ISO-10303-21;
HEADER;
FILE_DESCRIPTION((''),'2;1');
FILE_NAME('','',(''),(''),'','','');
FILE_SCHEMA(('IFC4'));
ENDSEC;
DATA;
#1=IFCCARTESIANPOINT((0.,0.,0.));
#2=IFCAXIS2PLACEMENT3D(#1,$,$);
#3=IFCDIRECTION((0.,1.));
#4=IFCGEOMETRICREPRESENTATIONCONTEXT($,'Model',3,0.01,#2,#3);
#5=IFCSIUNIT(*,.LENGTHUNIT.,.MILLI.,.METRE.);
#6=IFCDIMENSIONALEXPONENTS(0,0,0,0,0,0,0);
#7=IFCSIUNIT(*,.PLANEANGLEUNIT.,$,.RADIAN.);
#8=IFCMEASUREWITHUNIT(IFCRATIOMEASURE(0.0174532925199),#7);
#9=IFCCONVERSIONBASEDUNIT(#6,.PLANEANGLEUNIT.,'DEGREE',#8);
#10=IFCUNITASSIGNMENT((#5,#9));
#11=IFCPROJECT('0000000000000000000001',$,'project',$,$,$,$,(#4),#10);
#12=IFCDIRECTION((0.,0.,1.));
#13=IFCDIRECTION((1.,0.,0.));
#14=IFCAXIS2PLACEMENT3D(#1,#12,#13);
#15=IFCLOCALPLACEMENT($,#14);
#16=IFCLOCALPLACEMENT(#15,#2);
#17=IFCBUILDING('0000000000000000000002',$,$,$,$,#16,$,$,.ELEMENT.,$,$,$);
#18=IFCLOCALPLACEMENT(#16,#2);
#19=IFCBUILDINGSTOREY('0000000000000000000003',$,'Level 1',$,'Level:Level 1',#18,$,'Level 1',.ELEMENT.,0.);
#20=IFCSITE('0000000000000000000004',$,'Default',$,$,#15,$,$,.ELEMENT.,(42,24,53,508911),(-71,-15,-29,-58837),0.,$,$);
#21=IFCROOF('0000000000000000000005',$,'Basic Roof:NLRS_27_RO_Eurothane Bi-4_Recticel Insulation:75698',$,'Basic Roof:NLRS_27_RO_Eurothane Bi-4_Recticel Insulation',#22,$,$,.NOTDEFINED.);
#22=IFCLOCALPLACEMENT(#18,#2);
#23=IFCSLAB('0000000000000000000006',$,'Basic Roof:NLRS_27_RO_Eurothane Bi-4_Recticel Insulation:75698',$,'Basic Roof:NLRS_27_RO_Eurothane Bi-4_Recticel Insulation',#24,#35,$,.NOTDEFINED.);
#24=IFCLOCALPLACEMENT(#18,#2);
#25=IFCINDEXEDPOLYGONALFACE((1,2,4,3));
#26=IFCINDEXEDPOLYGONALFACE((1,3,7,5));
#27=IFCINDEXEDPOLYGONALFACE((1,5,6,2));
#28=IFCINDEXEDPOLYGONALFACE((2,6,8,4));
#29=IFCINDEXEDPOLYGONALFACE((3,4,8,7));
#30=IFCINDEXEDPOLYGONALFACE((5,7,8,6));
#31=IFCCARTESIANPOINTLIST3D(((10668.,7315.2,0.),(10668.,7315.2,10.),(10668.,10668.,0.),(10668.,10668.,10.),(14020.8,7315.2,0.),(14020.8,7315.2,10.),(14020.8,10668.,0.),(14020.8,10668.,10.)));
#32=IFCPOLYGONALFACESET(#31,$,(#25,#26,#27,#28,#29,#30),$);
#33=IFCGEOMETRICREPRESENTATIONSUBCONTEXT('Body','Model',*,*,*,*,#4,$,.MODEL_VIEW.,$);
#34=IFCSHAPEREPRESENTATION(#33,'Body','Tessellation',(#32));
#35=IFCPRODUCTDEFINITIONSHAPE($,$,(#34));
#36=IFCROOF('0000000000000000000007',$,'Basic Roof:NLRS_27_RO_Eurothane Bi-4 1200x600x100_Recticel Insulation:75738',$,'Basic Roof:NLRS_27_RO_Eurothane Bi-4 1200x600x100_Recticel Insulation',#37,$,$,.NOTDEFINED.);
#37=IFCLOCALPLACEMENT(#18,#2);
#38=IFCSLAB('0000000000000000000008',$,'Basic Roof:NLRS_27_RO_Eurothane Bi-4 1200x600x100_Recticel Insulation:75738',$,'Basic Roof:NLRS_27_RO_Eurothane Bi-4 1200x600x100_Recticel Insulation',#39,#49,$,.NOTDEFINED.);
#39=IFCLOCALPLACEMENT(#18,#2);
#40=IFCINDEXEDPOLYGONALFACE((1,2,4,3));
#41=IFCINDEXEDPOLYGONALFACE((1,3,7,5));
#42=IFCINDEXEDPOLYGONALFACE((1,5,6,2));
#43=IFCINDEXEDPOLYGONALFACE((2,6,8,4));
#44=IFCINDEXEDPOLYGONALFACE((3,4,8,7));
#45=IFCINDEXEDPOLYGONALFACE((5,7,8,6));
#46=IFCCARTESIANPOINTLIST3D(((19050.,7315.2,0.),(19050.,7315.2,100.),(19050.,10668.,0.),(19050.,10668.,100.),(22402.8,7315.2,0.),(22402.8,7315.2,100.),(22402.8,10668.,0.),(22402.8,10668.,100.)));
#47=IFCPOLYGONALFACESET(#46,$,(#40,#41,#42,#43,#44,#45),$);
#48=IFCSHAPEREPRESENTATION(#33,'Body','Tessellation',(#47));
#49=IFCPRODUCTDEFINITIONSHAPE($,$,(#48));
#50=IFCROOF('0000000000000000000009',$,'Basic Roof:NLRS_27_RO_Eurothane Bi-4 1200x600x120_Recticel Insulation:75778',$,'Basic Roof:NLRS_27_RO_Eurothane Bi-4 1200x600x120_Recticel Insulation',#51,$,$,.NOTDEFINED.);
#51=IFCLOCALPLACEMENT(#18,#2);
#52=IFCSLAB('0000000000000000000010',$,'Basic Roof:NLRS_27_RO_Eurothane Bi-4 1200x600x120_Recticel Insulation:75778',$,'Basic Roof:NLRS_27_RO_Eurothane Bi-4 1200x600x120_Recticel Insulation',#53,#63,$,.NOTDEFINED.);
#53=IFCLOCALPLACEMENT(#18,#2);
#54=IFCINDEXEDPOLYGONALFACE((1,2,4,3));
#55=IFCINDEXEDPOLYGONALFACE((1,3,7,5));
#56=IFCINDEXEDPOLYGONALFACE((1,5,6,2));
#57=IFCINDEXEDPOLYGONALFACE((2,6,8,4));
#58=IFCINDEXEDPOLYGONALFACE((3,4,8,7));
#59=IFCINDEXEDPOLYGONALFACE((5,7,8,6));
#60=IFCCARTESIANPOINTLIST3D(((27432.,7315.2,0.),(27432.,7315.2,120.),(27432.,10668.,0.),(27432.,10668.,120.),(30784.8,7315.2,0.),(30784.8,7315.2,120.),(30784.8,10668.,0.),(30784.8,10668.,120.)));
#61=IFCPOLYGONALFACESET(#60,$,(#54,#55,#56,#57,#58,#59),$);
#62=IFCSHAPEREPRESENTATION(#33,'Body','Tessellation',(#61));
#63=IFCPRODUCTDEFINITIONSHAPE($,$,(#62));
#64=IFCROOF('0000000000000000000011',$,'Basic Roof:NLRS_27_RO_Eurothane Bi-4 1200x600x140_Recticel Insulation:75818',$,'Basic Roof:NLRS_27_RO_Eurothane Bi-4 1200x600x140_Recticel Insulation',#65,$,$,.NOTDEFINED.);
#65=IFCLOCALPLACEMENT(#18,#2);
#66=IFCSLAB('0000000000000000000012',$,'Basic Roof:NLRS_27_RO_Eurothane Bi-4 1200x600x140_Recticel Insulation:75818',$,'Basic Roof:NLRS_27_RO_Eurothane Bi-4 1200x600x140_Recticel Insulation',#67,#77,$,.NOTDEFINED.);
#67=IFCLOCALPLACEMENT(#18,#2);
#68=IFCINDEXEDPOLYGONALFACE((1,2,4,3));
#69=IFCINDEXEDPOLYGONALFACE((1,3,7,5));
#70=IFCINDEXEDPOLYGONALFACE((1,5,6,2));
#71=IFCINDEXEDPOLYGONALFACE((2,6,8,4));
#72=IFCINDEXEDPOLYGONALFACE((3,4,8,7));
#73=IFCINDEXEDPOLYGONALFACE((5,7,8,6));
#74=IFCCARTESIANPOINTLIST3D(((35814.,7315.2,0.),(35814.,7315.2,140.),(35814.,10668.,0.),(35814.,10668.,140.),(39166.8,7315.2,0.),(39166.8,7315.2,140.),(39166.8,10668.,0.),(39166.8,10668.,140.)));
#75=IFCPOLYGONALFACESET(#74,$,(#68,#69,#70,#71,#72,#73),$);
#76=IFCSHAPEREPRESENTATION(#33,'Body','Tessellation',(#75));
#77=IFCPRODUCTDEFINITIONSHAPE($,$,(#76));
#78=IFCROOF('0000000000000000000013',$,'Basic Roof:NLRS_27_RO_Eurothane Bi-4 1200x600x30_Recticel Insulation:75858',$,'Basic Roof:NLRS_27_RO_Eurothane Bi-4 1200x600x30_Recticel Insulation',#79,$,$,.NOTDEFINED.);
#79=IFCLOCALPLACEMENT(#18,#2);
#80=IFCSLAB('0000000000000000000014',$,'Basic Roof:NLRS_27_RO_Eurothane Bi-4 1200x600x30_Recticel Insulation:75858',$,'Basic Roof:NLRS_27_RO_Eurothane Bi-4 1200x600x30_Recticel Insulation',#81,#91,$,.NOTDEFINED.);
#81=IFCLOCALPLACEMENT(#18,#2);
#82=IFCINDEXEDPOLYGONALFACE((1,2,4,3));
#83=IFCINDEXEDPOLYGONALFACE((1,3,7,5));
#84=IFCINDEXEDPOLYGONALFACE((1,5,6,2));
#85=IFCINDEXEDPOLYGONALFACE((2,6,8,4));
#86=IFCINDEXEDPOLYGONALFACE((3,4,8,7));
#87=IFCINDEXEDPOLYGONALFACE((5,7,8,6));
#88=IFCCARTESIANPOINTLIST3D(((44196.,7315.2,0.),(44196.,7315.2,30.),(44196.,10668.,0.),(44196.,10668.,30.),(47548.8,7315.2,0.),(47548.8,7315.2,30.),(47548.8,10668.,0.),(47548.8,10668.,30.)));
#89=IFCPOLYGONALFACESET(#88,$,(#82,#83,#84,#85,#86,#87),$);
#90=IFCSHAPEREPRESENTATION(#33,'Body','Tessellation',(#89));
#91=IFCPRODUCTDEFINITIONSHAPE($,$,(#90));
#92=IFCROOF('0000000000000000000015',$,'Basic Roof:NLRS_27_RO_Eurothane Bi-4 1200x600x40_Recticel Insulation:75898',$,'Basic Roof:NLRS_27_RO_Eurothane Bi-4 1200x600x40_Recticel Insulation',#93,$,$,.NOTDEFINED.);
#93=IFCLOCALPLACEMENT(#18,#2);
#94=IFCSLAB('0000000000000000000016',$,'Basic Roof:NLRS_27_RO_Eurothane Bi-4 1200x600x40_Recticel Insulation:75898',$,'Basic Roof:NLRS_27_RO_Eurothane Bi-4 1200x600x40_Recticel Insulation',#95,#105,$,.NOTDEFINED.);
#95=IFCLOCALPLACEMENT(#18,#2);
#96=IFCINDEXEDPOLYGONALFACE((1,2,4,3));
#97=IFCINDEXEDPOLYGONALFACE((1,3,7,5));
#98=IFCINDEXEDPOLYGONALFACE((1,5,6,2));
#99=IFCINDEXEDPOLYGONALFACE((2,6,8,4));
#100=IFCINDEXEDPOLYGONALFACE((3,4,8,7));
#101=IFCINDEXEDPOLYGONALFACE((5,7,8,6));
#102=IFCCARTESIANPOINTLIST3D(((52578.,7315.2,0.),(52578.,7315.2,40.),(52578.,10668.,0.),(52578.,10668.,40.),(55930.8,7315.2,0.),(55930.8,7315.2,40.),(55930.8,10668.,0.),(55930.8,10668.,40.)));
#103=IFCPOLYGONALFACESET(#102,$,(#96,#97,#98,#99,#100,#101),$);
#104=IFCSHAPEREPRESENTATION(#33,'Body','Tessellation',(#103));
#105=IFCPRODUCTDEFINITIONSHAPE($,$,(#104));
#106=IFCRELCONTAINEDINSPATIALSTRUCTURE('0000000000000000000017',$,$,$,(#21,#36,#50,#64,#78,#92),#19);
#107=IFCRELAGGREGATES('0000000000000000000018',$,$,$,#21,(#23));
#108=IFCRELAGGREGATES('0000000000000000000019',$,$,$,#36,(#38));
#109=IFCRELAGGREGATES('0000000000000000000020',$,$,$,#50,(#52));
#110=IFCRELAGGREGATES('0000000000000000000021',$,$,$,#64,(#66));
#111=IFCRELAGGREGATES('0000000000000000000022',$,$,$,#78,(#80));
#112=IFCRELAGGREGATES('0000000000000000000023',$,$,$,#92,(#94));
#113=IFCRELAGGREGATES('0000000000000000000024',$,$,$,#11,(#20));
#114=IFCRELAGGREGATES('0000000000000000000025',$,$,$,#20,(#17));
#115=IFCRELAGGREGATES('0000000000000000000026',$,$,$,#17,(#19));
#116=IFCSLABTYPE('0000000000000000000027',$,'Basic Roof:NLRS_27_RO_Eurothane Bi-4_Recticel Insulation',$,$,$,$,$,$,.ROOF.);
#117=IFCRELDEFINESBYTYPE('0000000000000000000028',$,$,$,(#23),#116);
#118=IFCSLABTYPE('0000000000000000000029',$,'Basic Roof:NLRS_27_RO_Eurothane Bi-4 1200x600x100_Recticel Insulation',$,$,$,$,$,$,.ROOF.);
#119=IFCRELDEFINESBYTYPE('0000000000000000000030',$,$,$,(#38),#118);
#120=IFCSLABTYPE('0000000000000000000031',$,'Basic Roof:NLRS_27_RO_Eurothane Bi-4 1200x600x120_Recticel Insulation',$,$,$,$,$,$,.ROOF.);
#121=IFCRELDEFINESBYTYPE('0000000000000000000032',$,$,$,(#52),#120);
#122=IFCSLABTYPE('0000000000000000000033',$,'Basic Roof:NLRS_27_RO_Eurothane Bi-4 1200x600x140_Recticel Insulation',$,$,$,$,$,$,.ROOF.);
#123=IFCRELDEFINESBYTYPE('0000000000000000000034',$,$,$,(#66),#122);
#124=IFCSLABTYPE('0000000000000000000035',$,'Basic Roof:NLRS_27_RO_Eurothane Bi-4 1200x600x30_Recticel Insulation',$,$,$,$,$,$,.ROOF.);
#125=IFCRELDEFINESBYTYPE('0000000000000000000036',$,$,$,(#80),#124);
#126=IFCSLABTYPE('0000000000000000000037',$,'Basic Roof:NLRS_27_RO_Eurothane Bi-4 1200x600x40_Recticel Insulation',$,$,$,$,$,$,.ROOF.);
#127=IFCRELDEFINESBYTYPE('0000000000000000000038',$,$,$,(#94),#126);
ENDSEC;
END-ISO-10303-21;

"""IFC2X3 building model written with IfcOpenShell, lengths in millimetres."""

from ifc_helpers import new_model, entity, si_unit, converted_unit, direction, frame, origin, origin_with_axes, origin_2d_with_axis, place, context, subcontext, project, spatial, rectangle, extrude, type_object, element, aggregate, save


model = new_model("IFC2X3")

# Units and contexts
model_context = context("Model", 3, precision=0.01, world=origin(), true_north=direction((0.0, 1.0)))
body_context = subcontext(model_context, "Body", "Model", "MODEL_VIEW")
ifc_project = project(units=[si_unit("LENGTHUNIT", "METRE", prefix="MILLI"), converted_unit("PLANEANGLEUNIT", "DEGREE", entity("IfcRatioMeasure", 0.0174532925199), si_unit("PLANEANGLEUNIT", "RADIAN"), dimensions=[0, 0, 0, 0, 0, 0, 0])], contexts=[model_context])

# Site, building, storey
site_placement = place(None, origin_with_axes())
site = spatial("IfcSite", under=ifc_project, at=site_placement, Name="Default", CompositionType="ELEMENT", RefLatitude=(42, 24, 53, 508911), RefLongitude=(-71, -15, -29, -58837), RefElevation=0.0)
building_placement = place(site_placement, origin())
building = spatial("IfcBuilding", under=site, at=building_placement, CompositionType="ELEMENT")
storey_placement = place(building_placement, origin())
storey = spatial("IfcBuildingStorey", under=building, at=storey_placement, Name="Level 1", ObjectType="Level:Level 1", LongName="Level 1", CompositionType="ELEMENT", Elevation=0.0)

# Roofs, slabs
roof_1_placement = place(storey_placement, frame((10668.0, 7315.2, 0.0)))
roof_1 = element("IfcRoof", 1, at=roof_1_placement, inside=storey, Name="Basic Roof:NLRS_27_RO_Eurothane Bi-4_Recticel Insulation:75698", ObjectType="Basic Roof:NLRS_27_RO_Eurothane Bi-4_Recticel Insulation", ShapeType="NOTDEFINED")
slab_type_1 = type_object("IfcSlabType", Name="Basic Roof:NLRS_27_RO_Eurothane Bi-4_Recticel Insulation", PredefinedType="ROOF")
slab_1_placement = place(roof_1_placement, origin())
slab_1 = element("IfcSlab", 2, at=slab_1_placement, type_object=slab_type_1, Name="Basic Roof:NLRS_27_RO_Eurothane Bi-4_Recticel Insulation:75698", ObjectType="Basic Roof:NLRS_27_RO_Eurothane Bi-4_Recticel Insulation", PredefinedType="NOTDEFINED", context=body_context, shape_type="SweptSolid", body=[
    extrude(rectangle(XDim=3352.8, YDim=3352.8, at=origin_2d_with_axis()), frame((1676.4, 1676.4, 0.0), x_axis=(-1.0, 0.0, 0.0)), (0.0, 0.0, 1.0), 10.0),
])
aggregate(roof_1, [slab_1])
roof_2_placement = place(storey_placement, frame((19050.0, 7315.2, 0.0)))
roof_2 = element("IfcRoof", 3, at=roof_2_placement, inside=storey, Name="Basic Roof:NLRS_27_RO_Eurothane Bi-4 1200x600x100_Recticel Insulation:75738", ObjectType="Basic Roof:NLRS_27_RO_Eurothane Bi-4 1200x600x100_Recticel Insulation", ShapeType="NOTDEFINED")
slab_type_2 = type_object("IfcSlabType", Name="Basic Roof:NLRS_27_RO_Eurothane Bi-4 1200x600x100_Recticel Insulation", PredefinedType="ROOF")
slab_2_placement = place(roof_2_placement, origin())
slab_2 = element("IfcSlab", 4, at=slab_2_placement, type_object=slab_type_2, Name="Basic Roof:NLRS_27_RO_Eurothane Bi-4 1200x600x100_Recticel Insulation:75738", ObjectType="Basic Roof:NLRS_27_RO_Eurothane Bi-4 1200x600x100_Recticel Insulation", PredefinedType="NOTDEFINED", context=body_context, shape_type="SweptSolid", body=[
    extrude(rectangle(XDim=3352.8, YDim=3352.8, at=origin_2d_with_axis()), frame((1676.4, 1676.4, 0.0), x_axis=(-1.0, 0.0, 0.0)), (0.0, 0.0, 1.0), 100.0),
])
aggregate(roof_2, [slab_2])
roof_3_placement = place(storey_placement, frame((27432.0, 7315.2, 0.0)))
roof_3 = element("IfcRoof", 5, at=roof_3_placement, inside=storey, Name="Basic Roof:NLRS_27_RO_Eurothane Bi-4 1200x600x120_Recticel Insulation:75778", ObjectType="Basic Roof:NLRS_27_RO_Eurothane Bi-4 1200x600x120_Recticel Insulation", ShapeType="NOTDEFINED")
slab_type_3 = type_object("IfcSlabType", Name="Basic Roof:NLRS_27_RO_Eurothane Bi-4 1200x600x120_Recticel Insulation", PredefinedType="ROOF")
slab_3_placement = place(roof_3_placement, origin())
slab_3 = element("IfcSlab", 6, at=slab_3_placement, type_object=slab_type_3, Name="Basic Roof:NLRS_27_RO_Eurothane Bi-4 1200x600x120_Recticel Insulation:75778", ObjectType="Basic Roof:NLRS_27_RO_Eurothane Bi-4 1200x600x120_Recticel Insulation", PredefinedType="NOTDEFINED", context=body_context, shape_type="SweptSolid", body=[
    extrude(rectangle(XDim=3352.8, YDim=3352.8, at=origin_2d_with_axis()), frame((1676.4, 1676.4, 0.0), x_axis=(-1.0, 0.0, 0.0)), (0.0, 0.0, 1.0), 120.0),
])
aggregate(roof_3, [slab_3])
roof_4_placement = place(storey_placement, frame((35814.0, 7315.2, 0.0)))
roof_4 = element("IfcRoof", 7, at=roof_4_placement, inside=storey, Name="Basic Roof:NLRS_27_RO_Eurothane Bi-4 1200x600x140_Recticel Insulation:75818", ObjectType="Basic Roof:NLRS_27_RO_Eurothane Bi-4 1200x600x140_Recticel Insulation", ShapeType="NOTDEFINED")
slab_type_4 = type_object("IfcSlabType", Name="Basic Roof:NLRS_27_RO_Eurothane Bi-4 1200x600x140_Recticel Insulation", PredefinedType="ROOF")
slab_4_placement = place(roof_4_placement, origin())
slab_4 = element("IfcSlab", 8, at=slab_4_placement, type_object=slab_type_4, Name="Basic Roof:NLRS_27_RO_Eurothane Bi-4 1200x600x140_Recticel Insulation:75818", ObjectType="Basic Roof:NLRS_27_RO_Eurothane Bi-4 1200x600x140_Recticel Insulation", PredefinedType="NOTDEFINED", context=body_context, shape_type="SweptSolid", body=[
    extrude(rectangle(XDim=3352.8, YDim=3352.8, at=origin_2d_with_axis()), frame((1676.4, 1676.4, 0.0), x_axis=(-1.0, 0.0, 0.0)), (0.0, 0.0, 1.0), 140.0),
])
aggregate(roof_4, [slab_4])
roof_5_placement = place(storey_placement, frame((44196.0, 7315.2, 0.0)))
roof_5 = element("IfcRoof", 9, at=roof_5_placement, inside=storey, Name="Basic Roof:NLRS_27_RO_Eurothane Bi-4 1200x600x30_Recticel Insulation:75858", ObjectType="Basic Roof:NLRS_27_RO_Eurothane Bi-4 1200x600x30_Recticel Insulation", ShapeType="NOTDEFINED")
slab_type_5 = type_object("IfcSlabType", Name="Basic Roof:NLRS_27_RO_Eurothane Bi-4 1200x600x30_Recticel Insulation", PredefinedType="ROOF")
slab_5_placement = place(roof_5_placement, origin())
slab_5 = element("IfcSlab", 10, at=slab_5_placement, type_object=slab_type_5, Name="Basic Roof:NLRS_27_RO_Eurothane Bi-4 1200x600x30_Recticel Insulation:75858", ObjectType="Basic Roof:NLRS_27_RO_Eurothane Bi-4 1200x600x30_Recticel Insulation", PredefinedType="NOTDEFINED", context=body_context, shape_type="SweptSolid", body=[
    extrude(rectangle(XDim=3352.8, YDim=3352.8, at=origin_2d_with_axis()), frame((1676.4, 1676.4, 0.0), x_axis=(-1.0, 0.0, 0.0)), (0.0, 0.0, 1.0), 30.0),
])
aggregate(roof_5, [slab_5])
roof_6_placement = place(storey_placement, frame((52578.0, 7315.2, 0.0)))
roof_6 = element("IfcRoof", 11, at=roof_6_placement, inside=storey, Name="Basic Roof:NLRS_27_RO_Eurothane Bi-4 1200x600x40_Recticel Insulation:75898", ObjectType="Basic Roof:NLRS_27_RO_Eurothane Bi-4 1200x600x40_Recticel Insulation", ShapeType="NOTDEFINED")
slab_type_6 = type_object("IfcSlabType", Name="Basic Roof:NLRS_27_RO_Eurothane Bi-4 1200x600x40_Recticel Insulation", PredefinedType="ROOF")
slab_6_placement = place(roof_6_placement, origin())
slab_6 = element("IfcSlab", 12, at=slab_6_placement, type_object=slab_type_6, Name="Basic Roof:NLRS_27_RO_Eurothane Bi-4 1200x600x40_Recticel Insulation:75898", ObjectType="Basic Roof:NLRS_27_RO_Eurothane Bi-4 1200x600x40_Recticel Insulation", PredefinedType="NOTDEFINED", context=body_context, shape_type="SweptSolid", body=[
    extrude(rectangle(XDim=3352.8, YDim=3352.8, at=origin_2d_with_axis()), frame((1676.4, 1676.4, 0.0), x_axis=(-1.0, 0.0, 0.0)), (0.0, 0.0, 1.0), 40.0),
])
aggregate(roof_6, [slab_6])

save(model, "model.ifc")
